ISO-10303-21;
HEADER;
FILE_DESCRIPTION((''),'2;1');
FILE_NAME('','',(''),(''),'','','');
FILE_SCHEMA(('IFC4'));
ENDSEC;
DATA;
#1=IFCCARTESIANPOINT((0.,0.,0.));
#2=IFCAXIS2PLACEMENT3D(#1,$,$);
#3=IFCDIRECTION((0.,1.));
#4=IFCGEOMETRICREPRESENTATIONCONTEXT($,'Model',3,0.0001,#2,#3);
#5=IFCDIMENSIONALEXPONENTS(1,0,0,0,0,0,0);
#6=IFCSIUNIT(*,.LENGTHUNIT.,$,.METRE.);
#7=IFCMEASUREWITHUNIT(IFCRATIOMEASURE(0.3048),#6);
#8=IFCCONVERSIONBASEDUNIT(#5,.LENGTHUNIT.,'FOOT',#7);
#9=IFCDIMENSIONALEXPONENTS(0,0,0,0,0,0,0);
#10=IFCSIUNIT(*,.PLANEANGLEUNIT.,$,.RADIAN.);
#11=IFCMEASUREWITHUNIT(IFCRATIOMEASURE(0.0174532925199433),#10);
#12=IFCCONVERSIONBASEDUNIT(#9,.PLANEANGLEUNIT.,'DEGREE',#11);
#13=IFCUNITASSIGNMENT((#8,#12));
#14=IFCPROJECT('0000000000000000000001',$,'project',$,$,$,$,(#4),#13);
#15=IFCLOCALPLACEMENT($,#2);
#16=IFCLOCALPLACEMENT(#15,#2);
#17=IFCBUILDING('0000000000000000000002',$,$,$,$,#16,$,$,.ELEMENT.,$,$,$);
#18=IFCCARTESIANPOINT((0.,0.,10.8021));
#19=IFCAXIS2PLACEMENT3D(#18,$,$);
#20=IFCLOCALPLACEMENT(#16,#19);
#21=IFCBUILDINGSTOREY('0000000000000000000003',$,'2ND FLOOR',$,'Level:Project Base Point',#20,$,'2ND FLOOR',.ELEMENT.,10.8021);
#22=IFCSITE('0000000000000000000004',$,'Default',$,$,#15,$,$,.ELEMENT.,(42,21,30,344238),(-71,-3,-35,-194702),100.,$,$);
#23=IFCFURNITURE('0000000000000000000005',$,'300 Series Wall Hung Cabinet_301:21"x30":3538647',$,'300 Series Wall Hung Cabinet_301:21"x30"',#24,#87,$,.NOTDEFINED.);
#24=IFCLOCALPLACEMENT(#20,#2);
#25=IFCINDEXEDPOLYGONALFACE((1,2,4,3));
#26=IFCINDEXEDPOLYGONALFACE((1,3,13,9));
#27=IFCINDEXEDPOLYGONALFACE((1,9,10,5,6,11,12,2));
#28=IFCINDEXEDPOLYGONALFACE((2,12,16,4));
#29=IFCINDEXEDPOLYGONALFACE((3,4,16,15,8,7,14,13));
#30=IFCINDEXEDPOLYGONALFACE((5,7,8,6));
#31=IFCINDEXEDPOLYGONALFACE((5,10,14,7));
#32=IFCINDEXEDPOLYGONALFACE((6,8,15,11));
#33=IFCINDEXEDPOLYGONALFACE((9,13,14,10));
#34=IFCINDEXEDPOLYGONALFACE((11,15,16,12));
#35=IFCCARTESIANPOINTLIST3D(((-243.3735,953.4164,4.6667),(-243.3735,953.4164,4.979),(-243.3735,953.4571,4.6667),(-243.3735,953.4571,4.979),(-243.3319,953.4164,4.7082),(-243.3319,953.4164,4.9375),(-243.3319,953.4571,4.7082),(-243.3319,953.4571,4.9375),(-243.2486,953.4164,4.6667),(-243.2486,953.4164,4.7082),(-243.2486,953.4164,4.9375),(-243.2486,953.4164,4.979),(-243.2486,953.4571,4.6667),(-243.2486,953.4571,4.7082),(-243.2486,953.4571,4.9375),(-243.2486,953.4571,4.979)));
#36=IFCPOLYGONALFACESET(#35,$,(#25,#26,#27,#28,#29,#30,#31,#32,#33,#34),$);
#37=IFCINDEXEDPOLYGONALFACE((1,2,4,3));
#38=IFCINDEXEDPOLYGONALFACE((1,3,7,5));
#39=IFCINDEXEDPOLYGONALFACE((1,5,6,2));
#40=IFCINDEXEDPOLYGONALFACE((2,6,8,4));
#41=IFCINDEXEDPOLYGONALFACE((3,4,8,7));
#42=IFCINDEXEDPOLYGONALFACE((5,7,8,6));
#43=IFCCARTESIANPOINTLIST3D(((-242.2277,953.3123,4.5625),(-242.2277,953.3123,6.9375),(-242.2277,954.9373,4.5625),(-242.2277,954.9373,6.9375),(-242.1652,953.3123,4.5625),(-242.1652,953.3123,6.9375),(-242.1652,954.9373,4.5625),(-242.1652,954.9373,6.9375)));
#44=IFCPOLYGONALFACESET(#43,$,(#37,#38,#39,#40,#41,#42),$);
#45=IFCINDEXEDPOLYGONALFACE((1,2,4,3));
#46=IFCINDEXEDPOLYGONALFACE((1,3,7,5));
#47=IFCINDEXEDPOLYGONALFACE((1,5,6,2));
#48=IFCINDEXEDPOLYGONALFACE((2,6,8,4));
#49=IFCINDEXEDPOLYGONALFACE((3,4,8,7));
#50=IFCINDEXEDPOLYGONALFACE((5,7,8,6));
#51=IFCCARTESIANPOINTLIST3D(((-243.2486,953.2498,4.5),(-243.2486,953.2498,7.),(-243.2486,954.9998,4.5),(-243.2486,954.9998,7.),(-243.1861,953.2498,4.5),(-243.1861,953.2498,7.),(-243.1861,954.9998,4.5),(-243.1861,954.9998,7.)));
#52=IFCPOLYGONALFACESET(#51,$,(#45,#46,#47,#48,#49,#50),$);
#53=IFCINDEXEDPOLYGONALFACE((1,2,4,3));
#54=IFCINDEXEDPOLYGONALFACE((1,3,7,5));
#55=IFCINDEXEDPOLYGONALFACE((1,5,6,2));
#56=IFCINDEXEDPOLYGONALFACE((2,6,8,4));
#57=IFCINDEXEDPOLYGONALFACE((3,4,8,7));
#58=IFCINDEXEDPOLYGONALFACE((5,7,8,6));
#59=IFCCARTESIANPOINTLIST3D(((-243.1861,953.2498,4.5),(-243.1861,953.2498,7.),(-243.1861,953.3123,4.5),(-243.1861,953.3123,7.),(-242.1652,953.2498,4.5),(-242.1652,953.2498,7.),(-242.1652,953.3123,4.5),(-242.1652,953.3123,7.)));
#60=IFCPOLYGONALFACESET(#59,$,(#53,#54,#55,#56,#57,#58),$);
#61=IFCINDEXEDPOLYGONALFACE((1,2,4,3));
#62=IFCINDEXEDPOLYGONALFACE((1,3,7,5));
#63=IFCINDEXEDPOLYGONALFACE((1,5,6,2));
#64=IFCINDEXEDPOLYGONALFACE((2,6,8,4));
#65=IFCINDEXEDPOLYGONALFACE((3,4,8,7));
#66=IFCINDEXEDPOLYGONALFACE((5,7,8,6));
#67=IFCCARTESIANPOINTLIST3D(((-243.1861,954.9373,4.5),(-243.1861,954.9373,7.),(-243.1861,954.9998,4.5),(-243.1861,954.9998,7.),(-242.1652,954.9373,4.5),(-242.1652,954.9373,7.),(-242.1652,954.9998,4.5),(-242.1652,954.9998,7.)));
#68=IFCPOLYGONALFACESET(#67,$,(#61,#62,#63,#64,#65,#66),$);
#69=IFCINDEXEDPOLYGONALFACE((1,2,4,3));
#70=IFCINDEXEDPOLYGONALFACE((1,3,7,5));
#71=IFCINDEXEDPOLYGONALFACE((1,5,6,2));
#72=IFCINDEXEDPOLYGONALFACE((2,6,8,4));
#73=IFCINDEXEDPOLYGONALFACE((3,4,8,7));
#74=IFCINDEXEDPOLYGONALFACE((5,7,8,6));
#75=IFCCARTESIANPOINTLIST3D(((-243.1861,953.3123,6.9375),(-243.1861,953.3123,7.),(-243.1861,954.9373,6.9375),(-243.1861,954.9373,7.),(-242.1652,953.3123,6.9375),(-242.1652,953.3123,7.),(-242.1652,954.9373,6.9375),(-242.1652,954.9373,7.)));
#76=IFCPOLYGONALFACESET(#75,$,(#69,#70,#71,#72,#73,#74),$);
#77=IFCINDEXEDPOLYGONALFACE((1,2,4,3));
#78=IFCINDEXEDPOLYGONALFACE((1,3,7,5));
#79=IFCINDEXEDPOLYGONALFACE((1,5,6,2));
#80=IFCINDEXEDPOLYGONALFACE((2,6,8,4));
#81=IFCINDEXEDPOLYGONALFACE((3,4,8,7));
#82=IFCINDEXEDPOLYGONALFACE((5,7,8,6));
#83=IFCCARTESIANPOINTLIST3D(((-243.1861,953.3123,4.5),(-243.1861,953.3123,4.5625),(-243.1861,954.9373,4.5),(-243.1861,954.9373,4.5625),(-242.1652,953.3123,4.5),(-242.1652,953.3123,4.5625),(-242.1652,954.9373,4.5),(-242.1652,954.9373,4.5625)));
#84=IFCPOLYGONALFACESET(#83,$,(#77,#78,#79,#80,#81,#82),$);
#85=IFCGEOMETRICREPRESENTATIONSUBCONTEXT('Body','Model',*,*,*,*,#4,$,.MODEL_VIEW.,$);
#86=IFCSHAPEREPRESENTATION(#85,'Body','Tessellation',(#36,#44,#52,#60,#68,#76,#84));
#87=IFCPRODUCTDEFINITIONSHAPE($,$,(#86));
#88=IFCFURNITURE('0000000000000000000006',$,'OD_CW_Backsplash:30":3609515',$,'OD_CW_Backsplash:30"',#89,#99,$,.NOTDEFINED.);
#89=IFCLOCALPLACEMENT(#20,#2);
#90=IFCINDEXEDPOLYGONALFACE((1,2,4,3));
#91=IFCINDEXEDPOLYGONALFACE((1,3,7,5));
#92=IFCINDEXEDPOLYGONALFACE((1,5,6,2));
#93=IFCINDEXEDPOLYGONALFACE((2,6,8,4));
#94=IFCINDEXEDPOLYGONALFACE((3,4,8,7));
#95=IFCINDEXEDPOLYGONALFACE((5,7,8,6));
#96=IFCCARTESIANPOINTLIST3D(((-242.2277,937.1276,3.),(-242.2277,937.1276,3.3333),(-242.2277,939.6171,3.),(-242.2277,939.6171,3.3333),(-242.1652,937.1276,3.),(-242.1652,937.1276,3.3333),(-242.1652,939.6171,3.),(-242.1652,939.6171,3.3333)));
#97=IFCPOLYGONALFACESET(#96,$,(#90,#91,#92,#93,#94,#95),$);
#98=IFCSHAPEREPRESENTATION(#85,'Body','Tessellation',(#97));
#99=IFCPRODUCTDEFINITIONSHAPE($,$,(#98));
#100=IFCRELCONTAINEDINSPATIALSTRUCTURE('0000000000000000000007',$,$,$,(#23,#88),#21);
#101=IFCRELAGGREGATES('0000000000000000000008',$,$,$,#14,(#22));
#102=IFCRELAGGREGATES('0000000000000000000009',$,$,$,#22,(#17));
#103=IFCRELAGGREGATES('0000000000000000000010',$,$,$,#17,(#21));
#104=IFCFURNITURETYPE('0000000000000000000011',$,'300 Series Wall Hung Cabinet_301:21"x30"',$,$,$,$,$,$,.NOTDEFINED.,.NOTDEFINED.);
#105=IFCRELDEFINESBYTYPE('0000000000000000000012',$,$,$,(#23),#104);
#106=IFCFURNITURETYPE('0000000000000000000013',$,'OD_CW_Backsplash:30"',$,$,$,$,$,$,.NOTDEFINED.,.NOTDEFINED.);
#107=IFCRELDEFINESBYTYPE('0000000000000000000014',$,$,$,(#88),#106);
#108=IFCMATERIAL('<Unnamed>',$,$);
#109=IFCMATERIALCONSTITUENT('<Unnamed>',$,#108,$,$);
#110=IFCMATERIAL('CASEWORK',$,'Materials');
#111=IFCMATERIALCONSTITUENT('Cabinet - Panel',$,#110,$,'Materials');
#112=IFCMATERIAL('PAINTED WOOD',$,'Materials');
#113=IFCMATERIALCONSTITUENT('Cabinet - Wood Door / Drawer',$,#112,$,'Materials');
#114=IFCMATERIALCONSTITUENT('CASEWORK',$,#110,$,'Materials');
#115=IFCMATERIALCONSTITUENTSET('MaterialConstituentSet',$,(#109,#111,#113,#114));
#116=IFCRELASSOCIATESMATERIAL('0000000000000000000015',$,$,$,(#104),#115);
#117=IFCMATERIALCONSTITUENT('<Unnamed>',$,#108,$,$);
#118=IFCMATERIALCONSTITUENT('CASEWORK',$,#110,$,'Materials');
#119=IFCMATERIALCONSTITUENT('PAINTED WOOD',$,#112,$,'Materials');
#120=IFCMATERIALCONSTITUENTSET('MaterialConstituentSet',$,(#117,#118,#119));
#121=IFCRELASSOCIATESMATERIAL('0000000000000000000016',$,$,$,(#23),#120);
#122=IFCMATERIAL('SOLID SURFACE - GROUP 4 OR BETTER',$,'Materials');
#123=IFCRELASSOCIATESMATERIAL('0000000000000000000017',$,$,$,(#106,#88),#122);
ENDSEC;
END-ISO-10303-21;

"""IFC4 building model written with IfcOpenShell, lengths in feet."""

from ifc_helpers import new_model, entity, si_unit, converted_unit, direction, frame, frame_2d, origin, origin_2d_with_axis, place, context, subcontext, project, spatial, polyline, rectangle, outline, extrude, source, transform, mapped, material, constituent, constituent_set, type_object, type_shapes, element, save


model = new_model("IFC4")

# Units and contexts
model_context = context("Model", 3, precision=0.0001, world=origin(), true_north=direction((0.0, 1.0)))
body_context = subcontext(model_context, "Body", "Model", "MODEL_VIEW")
ifc_project = project(units=[converted_unit("LENGTHUNIT", "FOOT", entity("IfcRatioMeasure", 0.3048), si_unit("LENGTHUNIT", "METRE"), dimensions=[1, 0, 0, 0, 0, 0, 0]), converted_unit("PLANEANGLEUNIT", "DEGREE", entity("IfcRatioMeasure", 0.0174532925199433), si_unit("PLANEANGLEUNIT", "RADIAN"), dimensions=[0, 0, 0, 0, 0, 0, 0])], contexts=[model_context])

# Site, building, storey
site_placement = place(None, origin())
site = spatial("IfcSite", under=ifc_project, at=site_placement, Name="Default", CompositionType="ELEMENT", RefLatitude=(42, 21, 30, 344238), RefLongitude=(-71, -3, -35, -194702), RefElevation=100.0)
building_placement = place(site_placement, origin())
building = spatial("IfcBuilding", under=site, at=building_placement, CompositionType="ELEMENT")
storey_placement = place(building_placement, frame((0.0, 0.0, 10.8021)))
storey = spatial("IfcBuildingStorey", under=building, at=storey_placement, Name="2ND FLOOR", ObjectType="Level:Project Base Point", LongName="2ND FLOOR", CompositionType="ELEMENT", Elevation=10.8021)

# Shared definitions
ifc_material_1 = material(Name="PAINTED WOOD", Category="Materials")
ifc_material_2 = material(Name="CASEWORK", Category="Materials")

# Furniture
ifc_material_3 = material(Name="SOLID SURFACE - GROUP 4 OR BETTER", Category="Materials")
ifc_material_4 = material(Name="<Unnamed>")
ifc_constituent_1 = constituent(ifc_material_4, Name="<Unnamed>")
ifc_constituent_2 = constituent(ifc_material_2, Name="CASEWORK", Category="Materials")
ifc_constituent_3 = constituent(ifc_material_1, Name="PAINTED WOOD", Category="Materials")
ifc_constituent_set_1 = constituent_set(constituents=[ifc_constituent_1, ifc_constituent_2, ifc_constituent_3], Name="MaterialConstituentSet")
ifc_constituent_4 = constituent(ifc_material_4, Name="<Unnamed>")
ifc_constituent_5 = constituent(ifc_material_2, Name="Cabinet - Panel", Category="Materials")
ifc_constituent_6 = constituent(ifc_material_1, Name="Cabinet - Wood Door / Drawer", Category="Materials")
ifc_constituent_7 = constituent(ifc_material_2, Name="CASEWORK", Category="Materials")
ifc_constituent_set_2 = constituent_set(constituents=[ifc_constituent_4, ifc_constituent_5, ifc_constituent_6, ifc_constituent_7], Name="MaterialConstituentSet")
furniture_type_1 = type_object("IfcFurnitureType", Name="300 Series Wall Hung Cabinet_301:21\"x30\"", AssemblyPlace="NOTDEFINED", PredefinedType="NOTDEFINED", material=ifc_constituent_set_2)
shared_shape_1 = source(origin(), body_context, "Body", "SweptSolid", [
    extrude(outline(polyline([(-0.0521, -0.1146), (-0.0521, -0.1562), (0.0729, -0.1562), (0.0729, 0.1562), (-0.0521, 0.1562), (-0.0521, 0.1146), (0.0313, 0.1146), (0.0313, -0.1146), (-0.0521, -0.1146)])), frame((0.1667, 1.1354, 0.3229), z_axis=(-1.0, 0.0, 0.0), x_axis=(0.0, 1.0, 0.0)), (0.0, 0.0, -1.0), 0.0407),
    extrude(rectangle(XDim=0.0625, YDim=1.625, at=origin_2d_with_axis()), frame((0.875, 0.0313, 0.0625), z_axis=(0.0, 0.0, 1.0), x_axis=(0.0, 1.0, 0.0)), (0.0, 0.0, 1.0), 2.375),
    extrude(rectangle(XDim=0.0625, YDim=1.75, at=origin_2d_with_axis()), frame((0.875, 1.0521, 0.0), z_axis=(0.0, 0.0, 1.0), x_axis=(0.0, 1.0, 0.0)), (0.0, 0.0, 1.0), 2.5),
    extrude(rectangle(XDim=0.0625, YDim=1.0208, at=frame_2d((0.0, 0.0), x_axis=(1.0, 0.0))), frame((0.0313, 0.5104, 0.0)), (0.0, 0.0, 1.0), 2.5),
    extrude(rectangle(XDim=0.0625, YDim=1.0208, at=frame_2d((0.0, 0.0), x_axis=(1.0, 0.0))), frame((1.7188, 0.5104, 0.0)), (0.0, 0.0, 1.0), 2.5),
    extrude(rectangle(XDim=1.625, YDim=1.0208, at=frame_2d((0.0, 0.0), x_axis=(1.0, 0.0))), frame((0.875, 0.5104, 2.4375), z_axis=(0.0, 0.0, 1.0), x_axis=(-1.0, 0.0, 0.0)), (0.0, 0.0, 1.0), 0.0625),
    extrude(rectangle(XDim=1.625, YDim=1.0208, at=origin_2d_with_axis()), frame((0.875, 0.5104, 0.0), z_axis=(0.0, 0.0, 1.0), x_axis=(-1.0, 0.0, 0.0)), (0.0, 0.0, 1.0), 0.0625),
])
type_shapes(furniture_type_1, [shared_shape_1])
furniture_1_placement = place(storey_placement, frame((-242.1652, 953.2498, 4.5), z_axis=(0.0, 0.0, 1.0), x_axis=(0.0, 1.0, 0.0)))
element("IfcFurniture", 1, at=furniture_1_placement, inside=storey, type_object=furniture_type_1, material=ifc_constituent_set_1, Name="300 Series Wall Hung Cabinet_301:21\"x30\":3538647", ObjectType="300 Series Wall Hung Cabinet_301:21\"x30\"", PredefinedType="NOTDEFINED", context=body_context, shape_type="MappedRepresentation", body=[
    mapped(shared_shape_1, transform((0.0, 0.0, 0.0), scale=1.0)),
])
furniture_type_2 = type_object("IfcFurnitureType", Name="OD_CW_Backsplash:30\"", AssemblyPlace="NOTDEFINED", PredefinedType="NOTDEFINED", material=ifc_material_3)
shared_shape_2 = source(origin(), body_context, "Body", "SweptSolid", [
    extrude(rectangle(XDim=2.4896, YDim=0.0625, at=frame_2d((0.0, 0.0), x_axis=(1.0, 0.0))), frame((1.2448, 0.0313, 0.0)), (0.0, 0.0, 1.0), 0.3333),
])
type_shapes(furniture_type_2, [shared_shape_2])
furniture_2_placement = place(storey_placement, frame((-242.1652, 937.1276, 3.0), z_axis=(0.0, 0.0, 1.0), x_axis=(0.0, 1.0, 0.0)))
element("IfcFurniture", 2, at=furniture_2_placement, inside=storey, type_object=furniture_type_2, material=ifc_material_3, Name="OD_CW_Backsplash:30\":3609515", ObjectType="OD_CW_Backsplash:30\"", PredefinedType="NOTDEFINED", context=body_context, shape_type="MappedRepresentation", body=[
    mapped(shared_shape_2, transform((0.0, 0.0, 0.0), scale=1.0)),
])

save(model, "model.ifc")
